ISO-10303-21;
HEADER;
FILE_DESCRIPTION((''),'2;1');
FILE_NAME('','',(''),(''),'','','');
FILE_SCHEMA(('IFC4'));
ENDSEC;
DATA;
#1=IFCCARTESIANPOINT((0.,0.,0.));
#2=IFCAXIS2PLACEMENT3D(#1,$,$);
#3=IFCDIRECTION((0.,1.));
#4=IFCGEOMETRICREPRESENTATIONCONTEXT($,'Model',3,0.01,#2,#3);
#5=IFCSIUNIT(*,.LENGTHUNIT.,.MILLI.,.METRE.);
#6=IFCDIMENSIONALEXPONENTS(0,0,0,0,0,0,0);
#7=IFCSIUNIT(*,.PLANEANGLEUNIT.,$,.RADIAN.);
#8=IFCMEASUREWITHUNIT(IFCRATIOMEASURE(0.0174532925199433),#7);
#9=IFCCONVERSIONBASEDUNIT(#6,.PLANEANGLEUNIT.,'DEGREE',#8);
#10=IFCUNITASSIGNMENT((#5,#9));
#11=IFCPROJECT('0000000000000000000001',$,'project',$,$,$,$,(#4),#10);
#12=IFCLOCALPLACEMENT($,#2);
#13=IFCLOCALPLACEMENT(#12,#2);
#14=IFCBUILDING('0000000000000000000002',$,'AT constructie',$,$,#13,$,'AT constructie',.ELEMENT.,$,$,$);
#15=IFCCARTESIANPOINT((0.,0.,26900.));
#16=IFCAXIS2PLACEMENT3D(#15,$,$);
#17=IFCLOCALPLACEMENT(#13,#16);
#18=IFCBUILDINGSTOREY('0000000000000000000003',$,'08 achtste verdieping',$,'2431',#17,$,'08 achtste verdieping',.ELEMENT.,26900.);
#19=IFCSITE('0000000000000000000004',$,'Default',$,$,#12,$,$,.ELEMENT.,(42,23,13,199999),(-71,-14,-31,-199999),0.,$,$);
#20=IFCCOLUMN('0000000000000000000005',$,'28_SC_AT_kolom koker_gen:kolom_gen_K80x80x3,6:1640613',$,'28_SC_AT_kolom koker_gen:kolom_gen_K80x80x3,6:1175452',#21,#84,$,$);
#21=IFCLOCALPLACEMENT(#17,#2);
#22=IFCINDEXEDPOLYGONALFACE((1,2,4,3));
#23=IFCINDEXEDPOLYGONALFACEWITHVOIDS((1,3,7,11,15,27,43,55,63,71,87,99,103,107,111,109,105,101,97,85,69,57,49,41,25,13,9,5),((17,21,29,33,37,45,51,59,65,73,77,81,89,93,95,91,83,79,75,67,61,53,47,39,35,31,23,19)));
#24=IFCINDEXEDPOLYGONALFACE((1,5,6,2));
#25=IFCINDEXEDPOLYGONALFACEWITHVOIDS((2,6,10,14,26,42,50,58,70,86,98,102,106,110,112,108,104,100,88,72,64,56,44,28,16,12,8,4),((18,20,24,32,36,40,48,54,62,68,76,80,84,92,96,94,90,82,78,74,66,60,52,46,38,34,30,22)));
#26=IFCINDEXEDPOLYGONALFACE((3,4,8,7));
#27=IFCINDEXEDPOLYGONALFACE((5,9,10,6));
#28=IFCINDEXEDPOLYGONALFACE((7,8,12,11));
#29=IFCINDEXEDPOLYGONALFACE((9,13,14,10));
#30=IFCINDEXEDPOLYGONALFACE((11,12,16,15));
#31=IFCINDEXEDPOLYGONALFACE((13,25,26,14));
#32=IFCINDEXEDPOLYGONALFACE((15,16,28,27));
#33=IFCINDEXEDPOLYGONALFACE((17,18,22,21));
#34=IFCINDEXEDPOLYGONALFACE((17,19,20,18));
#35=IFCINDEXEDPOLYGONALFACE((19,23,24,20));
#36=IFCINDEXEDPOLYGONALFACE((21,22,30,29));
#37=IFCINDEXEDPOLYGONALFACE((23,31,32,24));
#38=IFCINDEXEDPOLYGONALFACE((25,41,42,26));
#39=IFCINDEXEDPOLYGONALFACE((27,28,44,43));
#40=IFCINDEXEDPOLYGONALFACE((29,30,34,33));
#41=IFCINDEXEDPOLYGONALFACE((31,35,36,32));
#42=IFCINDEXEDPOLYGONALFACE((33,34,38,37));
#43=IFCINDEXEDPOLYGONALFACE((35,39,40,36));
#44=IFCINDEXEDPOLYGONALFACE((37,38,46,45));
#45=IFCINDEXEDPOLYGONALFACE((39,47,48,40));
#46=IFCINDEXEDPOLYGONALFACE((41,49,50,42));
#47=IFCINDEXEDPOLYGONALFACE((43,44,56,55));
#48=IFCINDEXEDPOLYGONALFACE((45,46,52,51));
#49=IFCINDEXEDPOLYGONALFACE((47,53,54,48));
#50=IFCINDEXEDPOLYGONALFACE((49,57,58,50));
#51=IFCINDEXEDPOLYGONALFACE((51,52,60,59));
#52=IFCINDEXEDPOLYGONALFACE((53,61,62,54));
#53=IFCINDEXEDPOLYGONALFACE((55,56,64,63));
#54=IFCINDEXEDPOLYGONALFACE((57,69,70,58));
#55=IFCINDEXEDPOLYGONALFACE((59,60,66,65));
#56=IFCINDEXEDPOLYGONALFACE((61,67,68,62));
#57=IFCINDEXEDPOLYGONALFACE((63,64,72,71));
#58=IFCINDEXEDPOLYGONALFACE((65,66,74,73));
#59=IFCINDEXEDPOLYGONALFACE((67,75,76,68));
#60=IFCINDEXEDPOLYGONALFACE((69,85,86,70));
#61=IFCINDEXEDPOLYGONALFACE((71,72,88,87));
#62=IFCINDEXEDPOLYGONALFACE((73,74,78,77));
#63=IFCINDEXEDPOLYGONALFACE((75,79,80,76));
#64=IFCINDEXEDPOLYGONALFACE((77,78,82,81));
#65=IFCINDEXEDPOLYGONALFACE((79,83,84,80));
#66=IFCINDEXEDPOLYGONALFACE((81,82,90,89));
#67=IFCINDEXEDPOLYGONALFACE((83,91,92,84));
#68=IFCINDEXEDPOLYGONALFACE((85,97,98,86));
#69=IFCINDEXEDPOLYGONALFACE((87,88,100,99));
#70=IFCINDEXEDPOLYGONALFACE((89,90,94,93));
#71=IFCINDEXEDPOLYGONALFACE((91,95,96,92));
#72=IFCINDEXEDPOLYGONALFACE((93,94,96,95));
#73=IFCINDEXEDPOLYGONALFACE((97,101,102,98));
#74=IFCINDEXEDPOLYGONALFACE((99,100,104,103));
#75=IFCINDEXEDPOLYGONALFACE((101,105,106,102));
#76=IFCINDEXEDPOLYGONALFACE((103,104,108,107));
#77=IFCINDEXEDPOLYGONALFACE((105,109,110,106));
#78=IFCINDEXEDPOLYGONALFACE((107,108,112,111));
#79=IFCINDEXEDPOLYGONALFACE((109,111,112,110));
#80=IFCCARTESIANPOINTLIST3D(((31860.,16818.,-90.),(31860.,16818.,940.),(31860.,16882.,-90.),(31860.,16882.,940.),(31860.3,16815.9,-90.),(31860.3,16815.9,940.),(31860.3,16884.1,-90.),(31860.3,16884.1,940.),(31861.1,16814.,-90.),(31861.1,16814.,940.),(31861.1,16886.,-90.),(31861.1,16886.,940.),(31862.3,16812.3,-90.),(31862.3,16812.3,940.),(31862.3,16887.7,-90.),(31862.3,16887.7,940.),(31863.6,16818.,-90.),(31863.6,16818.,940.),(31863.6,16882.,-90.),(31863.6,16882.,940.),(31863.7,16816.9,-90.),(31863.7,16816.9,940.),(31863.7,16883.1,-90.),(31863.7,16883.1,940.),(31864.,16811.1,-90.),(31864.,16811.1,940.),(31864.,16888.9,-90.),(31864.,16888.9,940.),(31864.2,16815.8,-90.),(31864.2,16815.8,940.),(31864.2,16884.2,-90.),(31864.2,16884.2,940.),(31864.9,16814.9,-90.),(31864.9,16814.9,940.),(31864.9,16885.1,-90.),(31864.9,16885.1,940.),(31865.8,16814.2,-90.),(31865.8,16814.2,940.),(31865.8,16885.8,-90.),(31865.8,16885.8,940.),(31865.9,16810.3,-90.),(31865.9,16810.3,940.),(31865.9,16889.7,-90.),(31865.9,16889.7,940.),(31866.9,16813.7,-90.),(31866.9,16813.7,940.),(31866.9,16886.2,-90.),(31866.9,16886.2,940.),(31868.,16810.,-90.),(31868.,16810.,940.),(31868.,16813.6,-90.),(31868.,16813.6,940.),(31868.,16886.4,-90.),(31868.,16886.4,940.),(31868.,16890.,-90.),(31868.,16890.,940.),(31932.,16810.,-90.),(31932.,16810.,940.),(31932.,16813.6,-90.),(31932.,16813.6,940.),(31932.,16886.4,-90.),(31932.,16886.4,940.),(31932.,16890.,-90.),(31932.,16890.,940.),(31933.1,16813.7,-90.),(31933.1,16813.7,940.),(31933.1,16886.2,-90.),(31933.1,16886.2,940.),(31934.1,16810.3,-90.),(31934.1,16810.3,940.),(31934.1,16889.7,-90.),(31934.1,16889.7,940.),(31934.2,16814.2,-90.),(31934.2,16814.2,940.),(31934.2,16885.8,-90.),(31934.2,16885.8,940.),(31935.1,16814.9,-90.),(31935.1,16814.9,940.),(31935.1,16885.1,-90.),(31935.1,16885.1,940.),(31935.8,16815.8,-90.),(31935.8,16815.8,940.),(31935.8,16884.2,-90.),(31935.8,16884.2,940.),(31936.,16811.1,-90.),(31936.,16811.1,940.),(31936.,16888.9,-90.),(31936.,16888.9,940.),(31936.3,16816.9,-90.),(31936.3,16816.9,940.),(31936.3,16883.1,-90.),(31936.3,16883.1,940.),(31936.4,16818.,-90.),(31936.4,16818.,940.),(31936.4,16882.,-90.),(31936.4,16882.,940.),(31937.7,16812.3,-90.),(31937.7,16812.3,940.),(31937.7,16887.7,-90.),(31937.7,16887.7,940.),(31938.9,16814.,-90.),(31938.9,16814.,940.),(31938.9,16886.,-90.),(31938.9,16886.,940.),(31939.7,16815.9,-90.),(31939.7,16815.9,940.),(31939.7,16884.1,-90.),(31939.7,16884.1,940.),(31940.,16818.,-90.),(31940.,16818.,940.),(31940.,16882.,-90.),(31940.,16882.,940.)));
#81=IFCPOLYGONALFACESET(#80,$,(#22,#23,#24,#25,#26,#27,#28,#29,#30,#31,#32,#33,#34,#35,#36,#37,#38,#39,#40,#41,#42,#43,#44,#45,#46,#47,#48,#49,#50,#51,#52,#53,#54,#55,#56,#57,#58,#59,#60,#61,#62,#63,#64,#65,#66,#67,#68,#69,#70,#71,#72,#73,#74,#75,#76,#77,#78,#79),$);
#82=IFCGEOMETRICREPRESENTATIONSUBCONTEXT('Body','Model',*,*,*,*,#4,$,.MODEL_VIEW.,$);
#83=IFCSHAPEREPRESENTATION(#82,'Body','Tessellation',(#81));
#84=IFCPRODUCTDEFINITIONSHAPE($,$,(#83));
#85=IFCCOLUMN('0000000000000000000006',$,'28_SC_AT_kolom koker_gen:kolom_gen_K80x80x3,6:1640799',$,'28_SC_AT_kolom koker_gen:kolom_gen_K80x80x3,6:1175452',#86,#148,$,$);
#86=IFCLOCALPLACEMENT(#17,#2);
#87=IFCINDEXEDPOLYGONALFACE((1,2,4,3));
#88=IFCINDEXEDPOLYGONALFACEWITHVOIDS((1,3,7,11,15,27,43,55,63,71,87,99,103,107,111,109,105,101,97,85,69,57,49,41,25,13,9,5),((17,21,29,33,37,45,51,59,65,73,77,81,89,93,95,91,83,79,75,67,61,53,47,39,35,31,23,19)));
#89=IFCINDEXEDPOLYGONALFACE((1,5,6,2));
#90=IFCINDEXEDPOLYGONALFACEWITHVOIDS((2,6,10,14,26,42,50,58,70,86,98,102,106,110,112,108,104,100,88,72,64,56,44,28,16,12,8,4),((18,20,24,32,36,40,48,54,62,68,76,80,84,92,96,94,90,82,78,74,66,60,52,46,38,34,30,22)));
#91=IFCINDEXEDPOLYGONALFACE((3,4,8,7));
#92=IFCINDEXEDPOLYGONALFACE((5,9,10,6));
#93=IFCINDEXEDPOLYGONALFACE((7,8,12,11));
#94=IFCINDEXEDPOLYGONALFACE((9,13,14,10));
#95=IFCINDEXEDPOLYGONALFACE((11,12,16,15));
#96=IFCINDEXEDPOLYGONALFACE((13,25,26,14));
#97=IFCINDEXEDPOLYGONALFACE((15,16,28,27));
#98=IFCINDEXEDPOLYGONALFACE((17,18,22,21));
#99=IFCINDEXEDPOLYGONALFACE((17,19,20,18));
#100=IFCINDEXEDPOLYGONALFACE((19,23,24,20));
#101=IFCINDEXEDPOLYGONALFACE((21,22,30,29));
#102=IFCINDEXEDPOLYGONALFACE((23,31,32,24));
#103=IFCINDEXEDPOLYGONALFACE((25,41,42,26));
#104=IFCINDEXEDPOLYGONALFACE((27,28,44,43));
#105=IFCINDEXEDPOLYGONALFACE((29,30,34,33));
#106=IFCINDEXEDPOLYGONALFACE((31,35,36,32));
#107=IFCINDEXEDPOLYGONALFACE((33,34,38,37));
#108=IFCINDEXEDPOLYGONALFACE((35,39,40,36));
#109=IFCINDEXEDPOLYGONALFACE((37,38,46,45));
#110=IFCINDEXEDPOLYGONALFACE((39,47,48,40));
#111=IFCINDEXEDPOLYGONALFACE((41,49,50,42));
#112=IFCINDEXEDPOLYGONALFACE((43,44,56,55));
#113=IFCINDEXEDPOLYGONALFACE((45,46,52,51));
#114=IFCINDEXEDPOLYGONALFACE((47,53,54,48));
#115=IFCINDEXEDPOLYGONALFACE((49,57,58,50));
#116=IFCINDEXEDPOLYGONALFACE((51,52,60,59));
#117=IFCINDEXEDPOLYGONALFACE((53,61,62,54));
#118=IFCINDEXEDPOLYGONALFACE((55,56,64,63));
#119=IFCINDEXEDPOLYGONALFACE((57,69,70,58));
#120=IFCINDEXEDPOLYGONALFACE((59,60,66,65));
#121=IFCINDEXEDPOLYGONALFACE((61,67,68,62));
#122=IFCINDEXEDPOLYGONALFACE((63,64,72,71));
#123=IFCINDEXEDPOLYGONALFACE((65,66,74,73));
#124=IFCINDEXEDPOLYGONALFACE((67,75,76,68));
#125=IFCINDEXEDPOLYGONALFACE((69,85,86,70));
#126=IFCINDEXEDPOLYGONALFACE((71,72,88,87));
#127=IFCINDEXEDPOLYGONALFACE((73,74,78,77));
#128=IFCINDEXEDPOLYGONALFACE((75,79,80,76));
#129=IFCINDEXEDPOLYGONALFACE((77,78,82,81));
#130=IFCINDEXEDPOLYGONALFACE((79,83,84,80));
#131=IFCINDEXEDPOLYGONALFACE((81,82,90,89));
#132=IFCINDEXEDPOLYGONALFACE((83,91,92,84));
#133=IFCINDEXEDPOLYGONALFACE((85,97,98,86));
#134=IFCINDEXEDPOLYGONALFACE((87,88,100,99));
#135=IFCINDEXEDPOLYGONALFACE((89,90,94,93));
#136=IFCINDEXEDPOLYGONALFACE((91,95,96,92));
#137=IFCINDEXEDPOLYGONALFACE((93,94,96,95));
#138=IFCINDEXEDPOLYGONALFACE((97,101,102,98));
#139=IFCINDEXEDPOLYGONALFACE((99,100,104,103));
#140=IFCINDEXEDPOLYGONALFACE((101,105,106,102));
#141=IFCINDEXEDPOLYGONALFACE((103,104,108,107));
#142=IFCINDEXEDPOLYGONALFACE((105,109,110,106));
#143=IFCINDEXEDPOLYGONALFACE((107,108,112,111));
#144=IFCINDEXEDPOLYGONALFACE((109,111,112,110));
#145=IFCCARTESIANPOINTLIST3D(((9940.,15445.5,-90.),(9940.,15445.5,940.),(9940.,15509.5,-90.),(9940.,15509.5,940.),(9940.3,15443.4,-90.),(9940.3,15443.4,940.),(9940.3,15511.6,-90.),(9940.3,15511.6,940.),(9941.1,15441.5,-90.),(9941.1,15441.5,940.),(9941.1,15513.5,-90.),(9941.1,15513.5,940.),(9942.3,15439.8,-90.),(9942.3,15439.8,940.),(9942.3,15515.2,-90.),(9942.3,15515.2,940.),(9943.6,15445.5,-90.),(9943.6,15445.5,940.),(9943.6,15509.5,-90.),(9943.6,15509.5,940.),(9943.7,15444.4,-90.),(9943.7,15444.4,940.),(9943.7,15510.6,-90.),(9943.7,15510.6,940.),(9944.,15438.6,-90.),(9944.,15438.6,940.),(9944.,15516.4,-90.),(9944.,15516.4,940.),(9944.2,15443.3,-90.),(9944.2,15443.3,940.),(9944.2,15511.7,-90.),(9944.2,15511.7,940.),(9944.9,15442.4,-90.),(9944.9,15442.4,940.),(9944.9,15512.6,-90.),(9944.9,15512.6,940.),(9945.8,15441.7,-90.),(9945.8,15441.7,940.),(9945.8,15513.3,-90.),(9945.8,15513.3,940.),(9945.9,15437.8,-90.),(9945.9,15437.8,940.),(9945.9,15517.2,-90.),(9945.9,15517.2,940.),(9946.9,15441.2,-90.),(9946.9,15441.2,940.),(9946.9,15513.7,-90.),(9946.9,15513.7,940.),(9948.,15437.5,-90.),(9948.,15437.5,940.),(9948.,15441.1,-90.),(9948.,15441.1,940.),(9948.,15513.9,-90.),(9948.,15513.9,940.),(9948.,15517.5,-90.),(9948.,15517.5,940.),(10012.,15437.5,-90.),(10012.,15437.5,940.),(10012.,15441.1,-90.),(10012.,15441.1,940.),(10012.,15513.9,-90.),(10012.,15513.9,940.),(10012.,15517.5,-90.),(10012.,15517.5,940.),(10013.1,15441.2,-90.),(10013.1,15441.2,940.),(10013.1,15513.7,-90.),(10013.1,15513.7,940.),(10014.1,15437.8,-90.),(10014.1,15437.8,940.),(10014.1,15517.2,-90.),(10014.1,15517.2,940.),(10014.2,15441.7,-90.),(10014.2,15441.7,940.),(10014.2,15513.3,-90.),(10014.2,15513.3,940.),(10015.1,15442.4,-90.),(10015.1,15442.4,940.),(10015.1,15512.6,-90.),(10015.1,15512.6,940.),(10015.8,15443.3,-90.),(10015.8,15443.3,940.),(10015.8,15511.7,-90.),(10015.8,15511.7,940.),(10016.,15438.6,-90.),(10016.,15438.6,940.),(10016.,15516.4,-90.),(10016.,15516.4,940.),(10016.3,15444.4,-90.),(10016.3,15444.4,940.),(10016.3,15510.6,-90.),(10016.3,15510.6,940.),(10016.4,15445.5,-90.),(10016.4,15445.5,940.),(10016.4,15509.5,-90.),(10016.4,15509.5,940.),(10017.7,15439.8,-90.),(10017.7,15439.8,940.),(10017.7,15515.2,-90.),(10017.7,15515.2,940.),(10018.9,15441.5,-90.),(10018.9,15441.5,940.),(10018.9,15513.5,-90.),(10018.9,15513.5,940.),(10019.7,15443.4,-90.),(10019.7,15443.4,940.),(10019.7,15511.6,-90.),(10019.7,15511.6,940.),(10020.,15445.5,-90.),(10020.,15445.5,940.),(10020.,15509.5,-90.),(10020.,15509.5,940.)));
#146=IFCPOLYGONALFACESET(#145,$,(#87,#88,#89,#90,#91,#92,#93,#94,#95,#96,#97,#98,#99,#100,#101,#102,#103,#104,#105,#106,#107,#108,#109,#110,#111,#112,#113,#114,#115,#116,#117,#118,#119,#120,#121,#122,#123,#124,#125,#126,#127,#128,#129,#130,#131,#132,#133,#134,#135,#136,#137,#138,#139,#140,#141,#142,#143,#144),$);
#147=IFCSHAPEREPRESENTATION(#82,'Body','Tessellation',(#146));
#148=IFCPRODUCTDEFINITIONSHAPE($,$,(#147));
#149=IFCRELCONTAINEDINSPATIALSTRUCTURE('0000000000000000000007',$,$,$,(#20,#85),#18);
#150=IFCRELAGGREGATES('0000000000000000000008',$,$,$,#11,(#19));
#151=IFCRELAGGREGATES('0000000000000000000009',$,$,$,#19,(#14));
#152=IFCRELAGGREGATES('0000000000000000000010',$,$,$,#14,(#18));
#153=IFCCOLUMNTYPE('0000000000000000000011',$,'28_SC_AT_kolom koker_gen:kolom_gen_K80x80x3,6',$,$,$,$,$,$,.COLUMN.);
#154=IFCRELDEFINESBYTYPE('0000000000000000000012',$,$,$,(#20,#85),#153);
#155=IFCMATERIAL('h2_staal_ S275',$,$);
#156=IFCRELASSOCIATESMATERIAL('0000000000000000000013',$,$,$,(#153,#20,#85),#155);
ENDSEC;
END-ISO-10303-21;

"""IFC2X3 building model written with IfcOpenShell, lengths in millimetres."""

from ifc_helpers import new_model, entity, si_unit, converted_unit, direction, frame, frame_2d, origin, place, context, subcontext, project, spatial, polyline, circle_curve, parameter, trimmed, segment, composite_curve, outline, extrude, source, transform, mapped, material, type_object, type_shapes, element, save


model = new_model("IFC2X3")

# Units and contexts
model_context = context("Model", 3, precision=0.01, world=origin(), true_north=direction((0.0, 1.0)))
body_context = subcontext(model_context, "Body", "Model", "MODEL_VIEW")
ifc_project = project(units=[si_unit("LENGTHUNIT", "METRE", prefix="MILLI"), converted_unit("PLANEANGLEUNIT", "DEGREE", entity("IfcRatioMeasure", 0.0174532925199433), si_unit("PLANEANGLEUNIT", "RADIAN"), dimensions=[0, 0, 0, 0, 0, 0, 0])], contexts=[model_context])

# Site, building, storey
site_placement = place(None, origin())
site = spatial("IfcSite", under=ifc_project, at=site_placement, Name="Default", CompositionType="ELEMENT", RefLatitude=(42, 23, 13, 199999), RefLongitude=(-71, -14, -31, -199999), RefElevation=0.0)
building_placement = place(site_placement, origin())
building = spatial("IfcBuilding", under=site, at=building_placement, Name="AT constructie", LongName="AT constructie", CompositionType="ELEMENT")
storey_placement = place(building_placement, frame((0.0, 0.0, 26900.0)))
storey = spatial("IfcBuildingStorey", under=building, at=storey_placement, Name="08 achtste verdieping", ObjectType="2431", LongName="08 achtste verdieping", CompositionType="ELEMENT", Elevation=26900.0)

# Columns
ifc_material_1 = material(Name="h2_staal_ S275")
column_type_1 = type_object("IfcColumnType", Name="28_SC_AT_kolom koker_gen:kolom_gen_K80x80x3,6", PredefinedType="COLUMN", material=ifc_material_1)
shared_shape_1 = source(origin(), body_context, "Body", "SweptSolid", [
    extrude(outline(composite_curve([segment(trimmed(circle_curve(frame_2d((32.0, 32.0), x_axis=(1.0, 0.0)), 8.0), [parameter(360.0)], [parameter(90.0)], True, "PARAMETER"), True, "CONTINUOUS"), segment(polyline([(32.0, 40.0), (-32.0, 40.0)]), True, "CONTINUOUS"), segment(trimmed(circle_curve(frame_2d((-32.0, 32.0), x_axis=(1.0, 0.0)), 8.0), [parameter(90.0)], [parameter(180.0)], True, "PARAMETER"), True, "CONTINUOUS"), segment(polyline([(-40.0, 32.0), (-40.0, -32.0)]), True, "CONTINUOUS"), segment(trimmed(circle_curve(frame_2d((-32.0, -32.0), x_axis=(1.0, 0.0)), 8.0), [parameter(180.0)], [parameter(270.0)], True, "PARAMETER"), True, "CONTINUOUS"), segment(polyline([(-32.0, -40.0), (32.0, -40.0)]), True, "CONTINUOUS"), segment(trimmed(circle_curve(frame_2d((32.0, -32.0), x_axis=(1.0, 0.0)), 8.0), [parameter(270.0)], [parameter(0.0)], True, "PARAMETER"), True, "CONTINUOUS"), segment(polyline([(40.0, -32.0), (40.0, 32.0)]), True, "CONTINUOUS")], self_intersect=False), holes=[composite_curve([segment(polyline([(-32.0, 36.4), (32.0, 36.4)]), True, "CONTINUOUS"), segment(trimmed(circle_curve(frame_2d((32.0, 32.0), x_axis=(1.0, 0.0)), 4.4), [parameter(360.0)], [parameter(90.0)], True, "PARAMETER"), False, "CONTINUOUS"), segment(polyline([(36.4, 32.0), (36.4, -32.0)]), True, "CONTINUOUS"), segment(trimmed(circle_curve(frame_2d((32.0, -32.0), x_axis=(1.0, 0.0)), 4.4), [parameter(270.0)], [parameter(360.0)], True, "PARAMETER"), False, "CONTINUOUS"), segment(polyline([(32.0, -36.4), (-32.0, -36.4)]), True, "CONTINUOUS"), segment(trimmed(circle_curve(frame_2d((-32.0, -32.0), x_axis=(1.0, 0.0)), 4.4), [parameter(180.0)], [parameter(270.0)], True, "PARAMETER"), False, "CONTINUOUS"), segment(polyline([(-36.4, -32.0), (-36.4, 32.0)]), True, "CONTINUOUS"), segment(trimmed(circle_curve(frame_2d((-32.0, 32.0), x_axis=(1.0, 0.0)), 4.4), [parameter(90.0)], [parameter(180.0)], True, "PARAMETER"), False, "CONTINUOUS")], self_intersect=False)]), frame((0.0, 0.0, 26810.0), z_axis=(0.0, 0.0, 1.0), x_axis=(-1.0, 0.0, 0.0)), (0.0, 0.0, 1.0), 1030.0),
])
type_shapes(column_type_1, [shared_shape_1])
for number, where, name in (
    (1, (31900.0, 16850.0, -26900.0), "28_SC_AT_kolom koker_gen:kolom_gen_K80x80x3,6:1640613"),
    (2, (9980.0, 15477.5, -26900.0), "28_SC_AT_kolom koker_gen:kolom_gen_K80x80x3,6:1640799"),
):
    element("IfcColumn", number, at=place(storey_placement, frame(where)), inside=storey, type_object=column_type_1, material=ifc_material_1, Name=name, ObjectType="28_SC_AT_kolom koker_gen:kolom_gen_K80x80x3,6:1175452", context=body_context, shape_type="MappedRepresentation", body=[
        mapped(shared_shape_1, transform((0.0, 0.0, 0.0), scale=1.0)),
    ])

save(model, "model.ifc")
